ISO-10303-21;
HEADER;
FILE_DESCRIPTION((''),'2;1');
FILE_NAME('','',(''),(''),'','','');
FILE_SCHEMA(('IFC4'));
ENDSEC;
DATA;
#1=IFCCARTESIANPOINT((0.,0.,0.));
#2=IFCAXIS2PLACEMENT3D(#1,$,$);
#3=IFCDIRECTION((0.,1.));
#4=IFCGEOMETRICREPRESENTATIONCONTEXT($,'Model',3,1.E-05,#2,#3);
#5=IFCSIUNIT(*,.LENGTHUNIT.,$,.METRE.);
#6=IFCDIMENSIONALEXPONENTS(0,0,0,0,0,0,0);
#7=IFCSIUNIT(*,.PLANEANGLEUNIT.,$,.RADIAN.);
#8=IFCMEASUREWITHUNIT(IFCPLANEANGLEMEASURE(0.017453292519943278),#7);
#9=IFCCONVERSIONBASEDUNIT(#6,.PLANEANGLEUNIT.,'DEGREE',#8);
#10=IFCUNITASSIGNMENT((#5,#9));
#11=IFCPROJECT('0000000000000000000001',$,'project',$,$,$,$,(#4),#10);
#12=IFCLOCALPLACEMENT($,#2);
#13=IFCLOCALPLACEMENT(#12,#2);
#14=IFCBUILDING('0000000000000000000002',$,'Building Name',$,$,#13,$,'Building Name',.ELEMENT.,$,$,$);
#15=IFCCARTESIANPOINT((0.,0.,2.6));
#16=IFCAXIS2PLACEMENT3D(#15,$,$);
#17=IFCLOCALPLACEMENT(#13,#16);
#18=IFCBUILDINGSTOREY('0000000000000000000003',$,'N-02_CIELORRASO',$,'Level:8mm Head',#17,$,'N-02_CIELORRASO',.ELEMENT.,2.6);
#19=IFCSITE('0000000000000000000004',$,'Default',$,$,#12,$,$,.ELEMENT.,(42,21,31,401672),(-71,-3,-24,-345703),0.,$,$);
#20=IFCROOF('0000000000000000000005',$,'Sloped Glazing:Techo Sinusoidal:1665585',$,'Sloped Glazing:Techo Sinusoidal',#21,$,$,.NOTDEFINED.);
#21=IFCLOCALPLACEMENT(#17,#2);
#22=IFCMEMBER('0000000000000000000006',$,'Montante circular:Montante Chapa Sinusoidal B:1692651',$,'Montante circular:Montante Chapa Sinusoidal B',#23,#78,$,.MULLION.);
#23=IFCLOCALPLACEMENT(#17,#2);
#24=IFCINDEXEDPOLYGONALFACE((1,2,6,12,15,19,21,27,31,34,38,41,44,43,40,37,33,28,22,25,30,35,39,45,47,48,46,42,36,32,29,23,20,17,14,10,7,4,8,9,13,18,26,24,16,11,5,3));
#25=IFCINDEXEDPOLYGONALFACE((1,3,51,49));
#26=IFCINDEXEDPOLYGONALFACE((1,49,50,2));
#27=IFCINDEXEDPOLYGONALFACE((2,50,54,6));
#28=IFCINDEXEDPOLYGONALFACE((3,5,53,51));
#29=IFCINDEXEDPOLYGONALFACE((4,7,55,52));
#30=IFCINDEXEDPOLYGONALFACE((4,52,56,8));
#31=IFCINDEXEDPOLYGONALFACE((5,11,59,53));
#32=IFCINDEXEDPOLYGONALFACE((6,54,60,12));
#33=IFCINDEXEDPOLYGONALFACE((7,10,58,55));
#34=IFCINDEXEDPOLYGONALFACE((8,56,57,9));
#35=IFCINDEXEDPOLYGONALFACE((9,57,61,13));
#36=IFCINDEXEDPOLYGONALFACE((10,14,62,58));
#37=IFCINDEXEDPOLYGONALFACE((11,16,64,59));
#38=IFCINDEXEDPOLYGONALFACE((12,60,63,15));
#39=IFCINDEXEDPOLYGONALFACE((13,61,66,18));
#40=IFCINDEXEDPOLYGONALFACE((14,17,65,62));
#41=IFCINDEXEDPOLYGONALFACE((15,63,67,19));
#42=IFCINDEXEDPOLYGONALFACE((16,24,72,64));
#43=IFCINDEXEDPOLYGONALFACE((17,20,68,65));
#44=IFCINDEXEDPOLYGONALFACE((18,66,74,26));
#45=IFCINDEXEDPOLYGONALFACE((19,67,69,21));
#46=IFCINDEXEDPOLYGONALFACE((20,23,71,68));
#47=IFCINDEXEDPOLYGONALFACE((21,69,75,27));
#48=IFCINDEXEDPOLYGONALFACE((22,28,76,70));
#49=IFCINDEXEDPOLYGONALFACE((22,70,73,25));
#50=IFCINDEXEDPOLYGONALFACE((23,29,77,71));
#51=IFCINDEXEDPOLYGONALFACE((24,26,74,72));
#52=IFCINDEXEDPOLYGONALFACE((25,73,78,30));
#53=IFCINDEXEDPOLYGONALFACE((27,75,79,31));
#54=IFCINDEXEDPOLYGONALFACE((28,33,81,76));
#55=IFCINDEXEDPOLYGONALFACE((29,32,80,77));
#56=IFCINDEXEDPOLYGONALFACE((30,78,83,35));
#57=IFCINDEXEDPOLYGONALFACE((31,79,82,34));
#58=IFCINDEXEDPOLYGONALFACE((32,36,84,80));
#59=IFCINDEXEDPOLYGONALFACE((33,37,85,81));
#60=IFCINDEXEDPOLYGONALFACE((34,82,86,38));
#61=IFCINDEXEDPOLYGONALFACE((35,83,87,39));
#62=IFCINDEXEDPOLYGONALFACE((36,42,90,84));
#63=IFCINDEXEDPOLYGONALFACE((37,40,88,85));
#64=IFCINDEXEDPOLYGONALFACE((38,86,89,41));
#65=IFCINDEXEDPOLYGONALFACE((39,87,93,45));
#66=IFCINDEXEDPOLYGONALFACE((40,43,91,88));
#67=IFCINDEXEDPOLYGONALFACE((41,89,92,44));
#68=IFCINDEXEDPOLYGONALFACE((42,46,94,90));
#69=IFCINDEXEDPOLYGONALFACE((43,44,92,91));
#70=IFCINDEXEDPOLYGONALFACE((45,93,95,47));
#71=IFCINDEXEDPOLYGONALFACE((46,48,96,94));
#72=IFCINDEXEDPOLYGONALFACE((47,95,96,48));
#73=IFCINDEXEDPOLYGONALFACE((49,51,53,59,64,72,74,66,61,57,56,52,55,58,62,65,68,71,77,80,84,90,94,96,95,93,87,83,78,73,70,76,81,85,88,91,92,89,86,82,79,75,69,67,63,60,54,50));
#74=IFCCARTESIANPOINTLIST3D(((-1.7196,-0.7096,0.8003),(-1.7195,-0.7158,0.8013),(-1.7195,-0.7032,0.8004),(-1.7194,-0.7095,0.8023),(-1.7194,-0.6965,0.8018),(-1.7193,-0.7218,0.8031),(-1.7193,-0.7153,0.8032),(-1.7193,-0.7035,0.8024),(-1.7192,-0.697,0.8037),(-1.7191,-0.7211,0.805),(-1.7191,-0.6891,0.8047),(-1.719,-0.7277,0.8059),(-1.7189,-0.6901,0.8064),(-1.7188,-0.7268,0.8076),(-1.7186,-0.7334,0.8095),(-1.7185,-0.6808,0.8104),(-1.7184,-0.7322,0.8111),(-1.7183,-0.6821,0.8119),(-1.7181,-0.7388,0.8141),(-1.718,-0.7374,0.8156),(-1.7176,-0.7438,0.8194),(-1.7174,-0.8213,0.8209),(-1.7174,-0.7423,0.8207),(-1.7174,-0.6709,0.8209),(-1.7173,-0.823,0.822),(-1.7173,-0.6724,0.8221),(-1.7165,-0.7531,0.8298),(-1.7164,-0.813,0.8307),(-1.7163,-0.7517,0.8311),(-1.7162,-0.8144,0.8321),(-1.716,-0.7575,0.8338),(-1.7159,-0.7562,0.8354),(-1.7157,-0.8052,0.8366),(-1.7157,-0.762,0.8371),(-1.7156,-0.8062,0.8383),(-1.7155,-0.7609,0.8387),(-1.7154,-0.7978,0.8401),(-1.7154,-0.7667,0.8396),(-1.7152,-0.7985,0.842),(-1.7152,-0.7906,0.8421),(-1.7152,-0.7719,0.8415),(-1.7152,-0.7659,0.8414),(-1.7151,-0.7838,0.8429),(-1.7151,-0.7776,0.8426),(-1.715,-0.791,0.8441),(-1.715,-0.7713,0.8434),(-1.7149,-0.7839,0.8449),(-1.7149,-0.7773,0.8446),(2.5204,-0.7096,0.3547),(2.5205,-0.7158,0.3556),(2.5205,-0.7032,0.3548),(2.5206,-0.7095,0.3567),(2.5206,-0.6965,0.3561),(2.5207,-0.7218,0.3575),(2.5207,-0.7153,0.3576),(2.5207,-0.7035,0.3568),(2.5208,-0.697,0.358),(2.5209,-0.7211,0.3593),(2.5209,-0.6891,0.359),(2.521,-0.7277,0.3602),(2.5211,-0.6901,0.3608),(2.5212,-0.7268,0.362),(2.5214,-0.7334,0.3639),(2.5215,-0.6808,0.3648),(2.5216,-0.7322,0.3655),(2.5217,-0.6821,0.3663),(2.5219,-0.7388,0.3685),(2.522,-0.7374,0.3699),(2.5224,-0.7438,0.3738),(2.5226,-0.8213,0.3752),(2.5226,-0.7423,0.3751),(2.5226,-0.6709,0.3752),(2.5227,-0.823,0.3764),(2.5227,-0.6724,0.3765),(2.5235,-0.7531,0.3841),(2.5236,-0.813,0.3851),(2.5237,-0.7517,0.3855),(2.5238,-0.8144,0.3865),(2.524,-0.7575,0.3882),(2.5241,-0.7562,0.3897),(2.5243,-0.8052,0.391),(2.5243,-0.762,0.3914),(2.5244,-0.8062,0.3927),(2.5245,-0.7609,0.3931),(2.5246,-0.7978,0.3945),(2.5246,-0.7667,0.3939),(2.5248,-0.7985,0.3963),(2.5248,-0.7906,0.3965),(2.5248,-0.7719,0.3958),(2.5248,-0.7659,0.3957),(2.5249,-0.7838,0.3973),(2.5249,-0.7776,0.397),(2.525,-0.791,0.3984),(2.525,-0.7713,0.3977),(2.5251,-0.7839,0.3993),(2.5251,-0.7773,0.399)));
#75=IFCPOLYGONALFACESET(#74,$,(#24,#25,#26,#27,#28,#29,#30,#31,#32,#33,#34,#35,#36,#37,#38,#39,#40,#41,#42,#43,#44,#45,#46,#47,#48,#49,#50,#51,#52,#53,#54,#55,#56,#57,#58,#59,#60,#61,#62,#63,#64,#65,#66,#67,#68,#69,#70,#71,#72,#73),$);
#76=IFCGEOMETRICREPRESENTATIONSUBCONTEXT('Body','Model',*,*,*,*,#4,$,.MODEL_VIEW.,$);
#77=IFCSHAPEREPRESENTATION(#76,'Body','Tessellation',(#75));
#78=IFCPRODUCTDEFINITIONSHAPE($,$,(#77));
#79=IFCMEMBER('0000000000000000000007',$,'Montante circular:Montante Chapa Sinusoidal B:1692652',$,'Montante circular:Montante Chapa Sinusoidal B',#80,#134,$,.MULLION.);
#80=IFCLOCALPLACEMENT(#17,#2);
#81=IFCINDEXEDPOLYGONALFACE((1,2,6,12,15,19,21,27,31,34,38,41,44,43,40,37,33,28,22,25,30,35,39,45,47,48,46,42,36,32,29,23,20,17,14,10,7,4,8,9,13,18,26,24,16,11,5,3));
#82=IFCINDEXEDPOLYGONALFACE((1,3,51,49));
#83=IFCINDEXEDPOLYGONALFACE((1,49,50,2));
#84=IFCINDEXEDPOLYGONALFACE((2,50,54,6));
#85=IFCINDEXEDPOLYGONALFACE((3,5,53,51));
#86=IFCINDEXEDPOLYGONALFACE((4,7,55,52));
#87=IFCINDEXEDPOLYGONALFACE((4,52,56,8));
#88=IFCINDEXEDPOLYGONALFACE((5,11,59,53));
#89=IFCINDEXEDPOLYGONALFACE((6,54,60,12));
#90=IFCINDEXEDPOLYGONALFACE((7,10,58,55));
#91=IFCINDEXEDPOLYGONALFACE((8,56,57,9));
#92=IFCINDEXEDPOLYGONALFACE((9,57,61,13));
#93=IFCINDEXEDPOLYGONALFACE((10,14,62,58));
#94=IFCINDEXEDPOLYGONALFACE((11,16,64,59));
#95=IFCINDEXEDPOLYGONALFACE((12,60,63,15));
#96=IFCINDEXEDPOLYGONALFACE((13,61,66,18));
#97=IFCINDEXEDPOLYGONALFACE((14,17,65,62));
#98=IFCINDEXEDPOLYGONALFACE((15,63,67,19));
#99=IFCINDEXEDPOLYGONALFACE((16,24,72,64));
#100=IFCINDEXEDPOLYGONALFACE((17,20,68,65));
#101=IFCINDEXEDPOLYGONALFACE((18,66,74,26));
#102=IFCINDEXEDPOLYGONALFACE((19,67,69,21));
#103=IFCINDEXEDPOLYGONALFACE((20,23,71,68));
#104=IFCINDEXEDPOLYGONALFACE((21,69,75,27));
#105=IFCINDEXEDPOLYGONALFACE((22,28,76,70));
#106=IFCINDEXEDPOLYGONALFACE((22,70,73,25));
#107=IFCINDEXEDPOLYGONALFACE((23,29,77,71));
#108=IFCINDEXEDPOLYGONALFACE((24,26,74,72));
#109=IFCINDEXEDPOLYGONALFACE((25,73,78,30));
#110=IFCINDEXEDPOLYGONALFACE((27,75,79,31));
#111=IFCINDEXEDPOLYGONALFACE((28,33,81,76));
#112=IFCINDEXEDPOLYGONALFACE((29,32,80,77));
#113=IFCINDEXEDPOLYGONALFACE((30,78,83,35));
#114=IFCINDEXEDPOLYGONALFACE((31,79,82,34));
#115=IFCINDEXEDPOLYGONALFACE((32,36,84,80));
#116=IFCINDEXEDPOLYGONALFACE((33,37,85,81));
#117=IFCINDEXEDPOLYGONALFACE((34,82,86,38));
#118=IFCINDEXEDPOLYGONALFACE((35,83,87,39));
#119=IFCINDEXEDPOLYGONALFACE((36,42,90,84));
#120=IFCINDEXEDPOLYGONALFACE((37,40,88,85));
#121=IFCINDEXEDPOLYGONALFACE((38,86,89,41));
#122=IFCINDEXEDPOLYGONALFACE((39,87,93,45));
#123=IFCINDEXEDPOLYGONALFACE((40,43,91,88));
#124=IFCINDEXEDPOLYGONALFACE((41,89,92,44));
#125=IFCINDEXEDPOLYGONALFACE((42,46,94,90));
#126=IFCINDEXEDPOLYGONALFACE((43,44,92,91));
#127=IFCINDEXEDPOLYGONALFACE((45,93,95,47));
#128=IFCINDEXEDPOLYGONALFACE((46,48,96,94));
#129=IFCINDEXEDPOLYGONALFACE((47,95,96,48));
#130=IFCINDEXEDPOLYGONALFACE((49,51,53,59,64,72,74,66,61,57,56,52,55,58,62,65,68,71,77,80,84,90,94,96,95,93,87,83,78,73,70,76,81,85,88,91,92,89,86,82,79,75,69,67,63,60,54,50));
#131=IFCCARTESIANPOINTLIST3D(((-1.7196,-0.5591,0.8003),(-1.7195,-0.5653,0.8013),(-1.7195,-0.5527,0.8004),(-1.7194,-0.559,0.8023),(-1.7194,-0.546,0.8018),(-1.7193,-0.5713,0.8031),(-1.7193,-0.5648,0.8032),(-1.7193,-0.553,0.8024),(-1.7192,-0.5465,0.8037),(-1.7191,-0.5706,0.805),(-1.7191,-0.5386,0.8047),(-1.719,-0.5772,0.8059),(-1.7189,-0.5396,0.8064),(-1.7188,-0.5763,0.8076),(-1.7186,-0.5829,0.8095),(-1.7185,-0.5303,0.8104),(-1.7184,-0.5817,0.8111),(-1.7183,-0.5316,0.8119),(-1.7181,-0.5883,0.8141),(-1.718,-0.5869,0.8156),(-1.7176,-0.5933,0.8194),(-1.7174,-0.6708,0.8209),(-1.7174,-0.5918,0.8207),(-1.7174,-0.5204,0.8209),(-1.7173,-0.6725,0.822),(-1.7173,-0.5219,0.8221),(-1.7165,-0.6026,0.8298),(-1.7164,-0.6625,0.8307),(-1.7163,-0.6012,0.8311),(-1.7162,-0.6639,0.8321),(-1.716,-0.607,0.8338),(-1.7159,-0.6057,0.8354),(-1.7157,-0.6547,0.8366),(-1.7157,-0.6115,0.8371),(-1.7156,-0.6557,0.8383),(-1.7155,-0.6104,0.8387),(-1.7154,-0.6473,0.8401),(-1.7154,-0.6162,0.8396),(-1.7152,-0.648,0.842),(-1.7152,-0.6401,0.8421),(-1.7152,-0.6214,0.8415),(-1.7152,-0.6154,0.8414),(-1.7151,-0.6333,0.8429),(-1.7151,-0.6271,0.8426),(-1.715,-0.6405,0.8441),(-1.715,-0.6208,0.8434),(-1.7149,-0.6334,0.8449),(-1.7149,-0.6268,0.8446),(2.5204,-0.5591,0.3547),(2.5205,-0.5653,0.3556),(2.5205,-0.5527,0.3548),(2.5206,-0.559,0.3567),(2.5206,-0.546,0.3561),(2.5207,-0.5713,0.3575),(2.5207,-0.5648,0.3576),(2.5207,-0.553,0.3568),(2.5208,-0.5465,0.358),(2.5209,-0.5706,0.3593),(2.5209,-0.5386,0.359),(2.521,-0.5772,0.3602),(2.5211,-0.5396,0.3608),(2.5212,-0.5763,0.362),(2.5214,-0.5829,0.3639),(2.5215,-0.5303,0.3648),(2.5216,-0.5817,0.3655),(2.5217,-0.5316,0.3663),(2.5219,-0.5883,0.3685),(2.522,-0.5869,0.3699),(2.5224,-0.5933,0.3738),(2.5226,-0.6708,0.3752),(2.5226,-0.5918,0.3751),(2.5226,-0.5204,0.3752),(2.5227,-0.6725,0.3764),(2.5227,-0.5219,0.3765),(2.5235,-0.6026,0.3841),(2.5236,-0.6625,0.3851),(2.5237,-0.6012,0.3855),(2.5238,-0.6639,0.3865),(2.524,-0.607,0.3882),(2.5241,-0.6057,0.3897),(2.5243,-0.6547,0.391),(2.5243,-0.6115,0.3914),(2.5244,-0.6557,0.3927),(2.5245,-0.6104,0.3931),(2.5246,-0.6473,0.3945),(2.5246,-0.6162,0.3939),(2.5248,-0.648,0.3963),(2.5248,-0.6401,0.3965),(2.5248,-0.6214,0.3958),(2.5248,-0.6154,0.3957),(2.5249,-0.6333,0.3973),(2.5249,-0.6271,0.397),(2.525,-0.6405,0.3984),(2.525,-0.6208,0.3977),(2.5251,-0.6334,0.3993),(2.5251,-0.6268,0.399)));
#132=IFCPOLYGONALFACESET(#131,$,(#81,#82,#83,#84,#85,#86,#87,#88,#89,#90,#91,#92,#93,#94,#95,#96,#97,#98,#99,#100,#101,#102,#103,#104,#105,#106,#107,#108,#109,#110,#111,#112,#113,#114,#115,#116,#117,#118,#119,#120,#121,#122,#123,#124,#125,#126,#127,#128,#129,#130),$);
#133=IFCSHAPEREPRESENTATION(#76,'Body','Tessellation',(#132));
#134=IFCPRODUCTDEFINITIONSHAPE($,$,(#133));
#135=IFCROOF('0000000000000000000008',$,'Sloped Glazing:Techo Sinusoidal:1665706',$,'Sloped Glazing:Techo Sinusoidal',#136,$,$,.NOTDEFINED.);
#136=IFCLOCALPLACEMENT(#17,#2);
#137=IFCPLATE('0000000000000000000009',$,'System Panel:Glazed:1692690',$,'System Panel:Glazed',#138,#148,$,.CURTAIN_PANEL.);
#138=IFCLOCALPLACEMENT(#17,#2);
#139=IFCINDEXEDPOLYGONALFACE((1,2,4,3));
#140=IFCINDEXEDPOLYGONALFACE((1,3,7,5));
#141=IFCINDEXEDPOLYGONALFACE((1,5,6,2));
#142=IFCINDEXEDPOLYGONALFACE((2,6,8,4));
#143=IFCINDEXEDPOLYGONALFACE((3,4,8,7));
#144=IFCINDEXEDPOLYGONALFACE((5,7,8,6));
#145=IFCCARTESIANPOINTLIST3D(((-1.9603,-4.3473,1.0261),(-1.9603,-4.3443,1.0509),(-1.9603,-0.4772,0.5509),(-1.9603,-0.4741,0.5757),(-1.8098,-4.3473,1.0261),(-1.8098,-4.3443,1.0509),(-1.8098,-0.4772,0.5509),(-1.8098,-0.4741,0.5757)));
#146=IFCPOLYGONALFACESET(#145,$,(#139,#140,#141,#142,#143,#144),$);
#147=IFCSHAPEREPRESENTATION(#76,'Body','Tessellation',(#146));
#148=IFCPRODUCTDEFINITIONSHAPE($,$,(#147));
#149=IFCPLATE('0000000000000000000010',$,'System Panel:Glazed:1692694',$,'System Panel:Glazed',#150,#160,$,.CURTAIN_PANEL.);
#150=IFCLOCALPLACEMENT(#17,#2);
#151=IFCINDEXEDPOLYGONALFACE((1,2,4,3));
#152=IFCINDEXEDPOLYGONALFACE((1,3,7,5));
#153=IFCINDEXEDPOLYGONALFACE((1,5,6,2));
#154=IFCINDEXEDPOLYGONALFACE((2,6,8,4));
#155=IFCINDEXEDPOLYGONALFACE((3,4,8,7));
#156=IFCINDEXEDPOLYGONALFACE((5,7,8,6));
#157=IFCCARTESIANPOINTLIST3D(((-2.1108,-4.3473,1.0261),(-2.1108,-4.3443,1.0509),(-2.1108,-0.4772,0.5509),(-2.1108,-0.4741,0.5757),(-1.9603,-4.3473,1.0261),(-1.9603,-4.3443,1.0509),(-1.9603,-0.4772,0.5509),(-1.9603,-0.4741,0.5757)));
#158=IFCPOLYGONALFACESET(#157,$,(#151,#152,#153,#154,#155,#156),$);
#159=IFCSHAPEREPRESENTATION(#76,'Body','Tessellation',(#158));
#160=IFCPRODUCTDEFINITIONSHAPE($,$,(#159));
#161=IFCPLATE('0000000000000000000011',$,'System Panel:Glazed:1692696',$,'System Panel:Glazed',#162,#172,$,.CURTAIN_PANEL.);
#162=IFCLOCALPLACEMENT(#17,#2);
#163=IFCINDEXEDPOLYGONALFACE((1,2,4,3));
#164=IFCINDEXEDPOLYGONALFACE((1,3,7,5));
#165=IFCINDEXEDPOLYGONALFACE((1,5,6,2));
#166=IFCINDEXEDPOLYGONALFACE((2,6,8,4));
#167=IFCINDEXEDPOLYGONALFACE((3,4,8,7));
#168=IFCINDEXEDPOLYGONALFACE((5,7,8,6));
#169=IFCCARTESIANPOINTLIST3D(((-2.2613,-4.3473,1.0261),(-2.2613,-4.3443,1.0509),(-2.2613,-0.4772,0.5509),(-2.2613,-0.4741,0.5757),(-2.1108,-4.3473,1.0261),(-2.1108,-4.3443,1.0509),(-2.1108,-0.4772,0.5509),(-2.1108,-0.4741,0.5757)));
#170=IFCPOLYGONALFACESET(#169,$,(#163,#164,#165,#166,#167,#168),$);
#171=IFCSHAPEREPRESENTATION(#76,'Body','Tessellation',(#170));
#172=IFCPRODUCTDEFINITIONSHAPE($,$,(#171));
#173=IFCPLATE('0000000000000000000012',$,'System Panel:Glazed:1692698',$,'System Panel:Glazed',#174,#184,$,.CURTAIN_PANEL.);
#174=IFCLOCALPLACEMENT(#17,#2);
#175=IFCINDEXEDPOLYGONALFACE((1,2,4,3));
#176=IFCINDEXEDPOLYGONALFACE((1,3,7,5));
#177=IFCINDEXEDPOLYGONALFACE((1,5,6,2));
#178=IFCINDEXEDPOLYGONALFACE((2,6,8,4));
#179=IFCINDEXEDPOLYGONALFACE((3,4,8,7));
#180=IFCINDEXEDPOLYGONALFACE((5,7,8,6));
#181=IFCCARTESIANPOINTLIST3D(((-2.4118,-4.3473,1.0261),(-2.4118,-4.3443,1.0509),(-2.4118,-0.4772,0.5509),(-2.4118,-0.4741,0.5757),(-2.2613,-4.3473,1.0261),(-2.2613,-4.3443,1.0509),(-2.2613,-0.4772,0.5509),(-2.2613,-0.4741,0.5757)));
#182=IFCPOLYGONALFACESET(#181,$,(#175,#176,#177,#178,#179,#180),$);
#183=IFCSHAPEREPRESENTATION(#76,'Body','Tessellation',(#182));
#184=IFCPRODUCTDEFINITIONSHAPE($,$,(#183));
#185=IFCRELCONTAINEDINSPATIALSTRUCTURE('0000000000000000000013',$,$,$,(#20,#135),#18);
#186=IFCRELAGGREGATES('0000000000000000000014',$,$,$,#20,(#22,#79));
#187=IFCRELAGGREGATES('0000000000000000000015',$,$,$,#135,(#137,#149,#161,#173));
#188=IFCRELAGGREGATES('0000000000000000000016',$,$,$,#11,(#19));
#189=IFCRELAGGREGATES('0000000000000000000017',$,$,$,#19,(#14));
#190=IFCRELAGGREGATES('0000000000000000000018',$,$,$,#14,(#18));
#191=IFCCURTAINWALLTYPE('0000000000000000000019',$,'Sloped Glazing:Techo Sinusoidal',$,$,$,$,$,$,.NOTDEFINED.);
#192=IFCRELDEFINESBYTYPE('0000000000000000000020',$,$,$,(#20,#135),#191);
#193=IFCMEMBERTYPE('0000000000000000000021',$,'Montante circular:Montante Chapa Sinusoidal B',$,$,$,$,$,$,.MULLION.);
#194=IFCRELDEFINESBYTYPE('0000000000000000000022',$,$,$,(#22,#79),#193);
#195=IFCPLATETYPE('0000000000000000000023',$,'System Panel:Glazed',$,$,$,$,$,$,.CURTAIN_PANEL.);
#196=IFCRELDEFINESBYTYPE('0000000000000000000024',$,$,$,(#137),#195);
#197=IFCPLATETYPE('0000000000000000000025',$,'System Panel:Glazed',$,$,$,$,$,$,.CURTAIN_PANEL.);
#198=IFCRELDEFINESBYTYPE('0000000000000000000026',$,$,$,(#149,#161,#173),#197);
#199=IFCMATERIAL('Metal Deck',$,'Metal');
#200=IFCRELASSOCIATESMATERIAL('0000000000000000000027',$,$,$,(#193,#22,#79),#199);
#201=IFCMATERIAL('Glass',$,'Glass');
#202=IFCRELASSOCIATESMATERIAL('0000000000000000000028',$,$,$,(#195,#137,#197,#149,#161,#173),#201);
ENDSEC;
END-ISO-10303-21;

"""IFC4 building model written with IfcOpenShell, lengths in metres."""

from ifc_helpers import new_model, entity, si_unit, converted_unit, direction, frame, origin, place, context, subcontext, project, spatial, indexed_curve, outline, extrude, source, transform, mapped, material, type_object, type_shapes, element, aggregate, save


model = new_model("IFC4")

# Units and contexts
model_context = context("Model", 3, precision=1e-05, world=origin(), true_north=direction((0.0, 1.0)))
body_context = subcontext(model_context, "Body", "Model", "MODEL_VIEW")
ifc_project = project(units=[si_unit("LENGTHUNIT", "METRE"), converted_unit("PLANEANGLEUNIT", "DEGREE", entity("IfcPlaneAngleMeasure", 0.017453292519943278), si_unit("PLANEANGLEUNIT", "RADIAN"), dimensions=[0, 0, 0, 0, 0, 0, 0])], contexts=[model_context])

# Site, building, storey
site_placement = place(None, origin())
site = spatial("IfcSite", under=ifc_project, at=site_placement, Name="Default", CompositionType="ELEMENT", RefLatitude=(42, 21, 31, 401672), RefLongitude=(-71, -3, -24, -345703), RefElevation=0.0)
building_placement = place(site_placement, origin())
building = spatial("IfcBuilding", under=site, at=building_placement, Name="Building Name", LongName="Building Name", CompositionType="ELEMENT")
storey_placement = place(building_placement, frame((0.0, 0.0, 2.6)))
storey = spatial("IfcBuildingStorey", under=building, at=storey_placement, Name="N-02_CIELORRASO", ObjectType="Level:8mm Head", LongName="N-02_CIELORRASO", CompositionType="ELEMENT", Elevation=2.6)

# Roof, members
curtain_wall_type = type_object("IfcCurtainWallType", Name="Sloped Glazing:Techo Sinusoidal", PredefinedType="NOTDEFINED")
roof_1_placement = place(storey_placement, frame((0.0, 0.0, -2.6)))
roof_1 = element("IfcRoof", 1, at=roof_1_placement, inside=storey, type_object=curtain_wall_type, Name="Sloped Glazing:Techo Sinusoidal:1665585", ObjectType="Sloped Glazing:Techo Sinusoidal", PredefinedType="NOTDEFINED")
ifc_material_1 = material(Name="Metal Deck", Category="Metal")
member_type = type_object("IfcMemberType", Name="Montante circular:Montante Chapa Sinusoidal B", PredefinedType="MULLION", material=ifc_material_1)
shared_shape_1 = source(origin(), body_context, "Body", "SweptSolid", [
    extrude(outline(indexed_curve([(0.0595, -0.0443), (0.0615, -0.0443), (0.0603, -0.031), (0.0572, -0.0213), (0.053, -0.0138), (0.0481, -0.0078), (0.0427, -0.003), (0.0372, 0.0005), (0.0315, 0.0029), (0.0259, 0.0044), (0.0203, 0.0051), (0.0146, 0.005), (0.0084, 0.0041), (-0.0053, 0.0009), (-0.0123, -0.0005), (-0.0191, -0.0012), (-0.0256, -0.001), (-0.0317, 0.0001), (-0.0375, 0.0019), (-0.0428, 0.0046), (-0.0477, 0.0081), (-0.0522, 0.0128), (-0.0563, 0.0191), (-0.0597, 0.0282), (-0.0617, 0.0421), (-0.0637, 0.042), (-0.0616, 0.0277), (-0.0581, 0.0182), (-0.0537, 0.0116), (-0.049, 0.0066), (-0.0438, 0.0028), (-0.0382, 0.0001), (-0.0322, -0.0019), (-0.0258, -0.003), (-0.019, -0.0032), (-0.012, -0.0025), (-0.0048, -0.0011), (0.0088, 0.0021), (0.0147, 0.003), (0.0202, 0.0031), (0.0255, 0.0024), (0.0309, 0.001), (0.0362, -0.0013), (0.0415, -0.0046), (0.0466, -0.0092), (0.0513, -0.0149), (0.0554, -0.0221), (0.0584, -0.0314), (0.0595, -0.0443)], self_intersect=False)), frame((-0.007, 0.0228, -4.2634), z_axis=(0.0, 0.0, 1.0), x_axis=(-0.819152, -0.573576, 0.0)), (0.0, 0.0, 1.0), 4.2634),
])
type_shapes(member_type, [shared_shape_1])
member_1_placement = place(roof_1_placement, frame((-1.7148, -0.7401, 3.4456), z_axis=(-0.994522, 0.0, 0.104528), x_axis=(0.0, 1.0, 0.0)))
member_1 = element("IfcMember", 2, at=member_1_placement, type_object=member_type, material=ifc_material_1, Name="Montante circular:Montante Chapa Sinusoidal B:1692651", ObjectType="Montante circular:Montante Chapa Sinusoidal B", PredefinedType="MULLION", context=body_context, shape_type="MappedRepresentation", body=[
    mapped(shared_shape_1, transform((0.0, 0.0, 0.0), scale=1.0)),
])
member_2_placement = place(roof_1_placement, frame((-1.7148, -0.5896, 3.4456), z_axis=(-0.994522, 0.0, 0.104528), x_axis=(0.0, 1.0, 0.0)))
member_2 = element("IfcMember", 3, at=member_2_placement, type_object=member_type, material=ifc_material_1, Name="Montante circular:Montante Chapa Sinusoidal B:1692652", ObjectType="Montante circular:Montante Chapa Sinusoidal B", PredefinedType="MULLION", context=body_context, shape_type="MappedRepresentation", body=[
    mapped(shared_shape_1, transform((0.0, 0.0, 0.0), scale=1.0)),
])
aggregate(roof_1, [member_1, member_2])

# Roof, plates
roof_2_placement = place(storey_placement, frame((0.0, 0.0, -2.6)))
roof_2 = element("IfcRoof", 4, at=roof_2_placement, inside=storey, type_object=curtain_wall_type, Name="Sloped Glazing:Techo Sinusoidal:1665706", ObjectType="Sloped Glazing:Techo Sinusoidal", PredefinedType="NOTDEFINED")
ifc_material_2 = material(Name="Glass", Category="Glass")
plate_type_1 = type_object("IfcPlateType", Name="System Panel:Glazed", PredefinedType="CURTAIN_PANEL", material=ifc_material_2)
shared_shape_2 = source(origin(), body_context, "Body", "SweptSolid", [
    extrude(outline(indexed_curve([(-0.0125, -0.0753), (0.0125, -0.0753), (0.0125, 0.0753), (-0.0125, 0.0753), (-0.0125, -0.0753)], self_intersect=False)), frame((0.0, 0.037, 0.0), z_axis=(0.0, 0.0, 1.0), x_axis=(0.0, 1.0, 0.0)), (0.0, 0.0, 1.0), 3.8992),
])
type_shapes(plate_type_1, [shared_shape_2])
plate_1_placement = place(roof_2_placement, frame((-1.885, -0.4711, 3.2), z_axis=(0.0, -0.992546, 0.121869), x_axis=(-1.0, 0.0, 0.0)))
plate_1 = element("IfcPlate", 5, at=plate_1_placement, type_object=plate_type_1, material=ifc_material_2, Name="System Panel:Glazed:1692690", ObjectType="System Panel:Glazed", PredefinedType="CURTAIN_PANEL", context=body_context, shape_type="MappedRepresentation", body=[
    mapped(shared_shape_2, transform((0.0, 0.0, 0.0), scale=1.0)),
])
plate_type_2 = type_object("IfcPlateType", Name="System Panel:Glazed", PredefinedType="CURTAIN_PANEL", material=ifc_material_2)
shared_shape_3 = source(origin(), body_context, "Body", "SweptSolid", [
    extrude(outline(indexed_curve([(-0.0125, -0.0753), (0.0125, -0.0753), (0.0125, 0.0753), (-0.0125, 0.0753), (-0.0125, -0.0753)], self_intersect=False)), frame((0.0, 0.037, 0.0), z_axis=(0.0, 0.0, 1.0), x_axis=(0.0, 1.0, 0.0)), (0.0, 0.0, 1.0), 3.8992),
])
type_shapes(plate_type_2, [shared_shape_3])
plate_2_placement = place(roof_2_placement, frame((-2.0355, -0.4711, 3.2), z_axis=(0.0, -0.992546, 0.121869), x_axis=(-1.0, 0.0, 0.0)))
plate_2 = element("IfcPlate", 6, at=plate_2_placement, type_object=plate_type_2, material=ifc_material_2, Name="System Panel:Glazed:1692694", ObjectType="System Panel:Glazed", PredefinedType="CURTAIN_PANEL", context=body_context, shape_type="MappedRepresentation", body=[
    mapped(shared_shape_3, transform((0.0, 0.0, 0.0), scale=1.0)),
])
plate_3_placement = place(roof_2_placement, frame((-2.186, -0.4711, 3.2), z_axis=(0.0, -0.992546, 0.121869), x_axis=(-1.0, 0.0, 0.0)))
plate_3 = element("IfcPlate", 7, at=plate_3_placement, type_object=plate_type_2, material=ifc_material_2, Name="System Panel:Glazed:1692696", ObjectType="System Panel:Glazed", PredefinedType="CURTAIN_PANEL", context=body_context, shape_type="MappedRepresentation", body=[
    mapped(shared_shape_3, transform((0.0, 0.0, 0.0), scale=1.0)),
])
plate_4_placement = place(roof_2_placement, frame((-2.3365, -0.4711, 3.2), z_axis=(0.0, -0.992546, 0.121869), x_axis=(-1.0, 0.0, 0.0)))
plate_4 = element("IfcPlate", 8, at=plate_4_placement, type_object=plate_type_2, material=ifc_material_2, Name="System Panel:Glazed:1692698", ObjectType="System Panel:Glazed", PredefinedType="CURTAIN_PANEL", context=body_context, shape_type="MappedRepresentation", body=[
    mapped(shared_shape_3, transform((0.0, 0.0, 0.0), scale=1.0)),
])
aggregate(roof_2, [plate_1, plate_2, plate_3, plate_4])

save(model, "model.ifc")
